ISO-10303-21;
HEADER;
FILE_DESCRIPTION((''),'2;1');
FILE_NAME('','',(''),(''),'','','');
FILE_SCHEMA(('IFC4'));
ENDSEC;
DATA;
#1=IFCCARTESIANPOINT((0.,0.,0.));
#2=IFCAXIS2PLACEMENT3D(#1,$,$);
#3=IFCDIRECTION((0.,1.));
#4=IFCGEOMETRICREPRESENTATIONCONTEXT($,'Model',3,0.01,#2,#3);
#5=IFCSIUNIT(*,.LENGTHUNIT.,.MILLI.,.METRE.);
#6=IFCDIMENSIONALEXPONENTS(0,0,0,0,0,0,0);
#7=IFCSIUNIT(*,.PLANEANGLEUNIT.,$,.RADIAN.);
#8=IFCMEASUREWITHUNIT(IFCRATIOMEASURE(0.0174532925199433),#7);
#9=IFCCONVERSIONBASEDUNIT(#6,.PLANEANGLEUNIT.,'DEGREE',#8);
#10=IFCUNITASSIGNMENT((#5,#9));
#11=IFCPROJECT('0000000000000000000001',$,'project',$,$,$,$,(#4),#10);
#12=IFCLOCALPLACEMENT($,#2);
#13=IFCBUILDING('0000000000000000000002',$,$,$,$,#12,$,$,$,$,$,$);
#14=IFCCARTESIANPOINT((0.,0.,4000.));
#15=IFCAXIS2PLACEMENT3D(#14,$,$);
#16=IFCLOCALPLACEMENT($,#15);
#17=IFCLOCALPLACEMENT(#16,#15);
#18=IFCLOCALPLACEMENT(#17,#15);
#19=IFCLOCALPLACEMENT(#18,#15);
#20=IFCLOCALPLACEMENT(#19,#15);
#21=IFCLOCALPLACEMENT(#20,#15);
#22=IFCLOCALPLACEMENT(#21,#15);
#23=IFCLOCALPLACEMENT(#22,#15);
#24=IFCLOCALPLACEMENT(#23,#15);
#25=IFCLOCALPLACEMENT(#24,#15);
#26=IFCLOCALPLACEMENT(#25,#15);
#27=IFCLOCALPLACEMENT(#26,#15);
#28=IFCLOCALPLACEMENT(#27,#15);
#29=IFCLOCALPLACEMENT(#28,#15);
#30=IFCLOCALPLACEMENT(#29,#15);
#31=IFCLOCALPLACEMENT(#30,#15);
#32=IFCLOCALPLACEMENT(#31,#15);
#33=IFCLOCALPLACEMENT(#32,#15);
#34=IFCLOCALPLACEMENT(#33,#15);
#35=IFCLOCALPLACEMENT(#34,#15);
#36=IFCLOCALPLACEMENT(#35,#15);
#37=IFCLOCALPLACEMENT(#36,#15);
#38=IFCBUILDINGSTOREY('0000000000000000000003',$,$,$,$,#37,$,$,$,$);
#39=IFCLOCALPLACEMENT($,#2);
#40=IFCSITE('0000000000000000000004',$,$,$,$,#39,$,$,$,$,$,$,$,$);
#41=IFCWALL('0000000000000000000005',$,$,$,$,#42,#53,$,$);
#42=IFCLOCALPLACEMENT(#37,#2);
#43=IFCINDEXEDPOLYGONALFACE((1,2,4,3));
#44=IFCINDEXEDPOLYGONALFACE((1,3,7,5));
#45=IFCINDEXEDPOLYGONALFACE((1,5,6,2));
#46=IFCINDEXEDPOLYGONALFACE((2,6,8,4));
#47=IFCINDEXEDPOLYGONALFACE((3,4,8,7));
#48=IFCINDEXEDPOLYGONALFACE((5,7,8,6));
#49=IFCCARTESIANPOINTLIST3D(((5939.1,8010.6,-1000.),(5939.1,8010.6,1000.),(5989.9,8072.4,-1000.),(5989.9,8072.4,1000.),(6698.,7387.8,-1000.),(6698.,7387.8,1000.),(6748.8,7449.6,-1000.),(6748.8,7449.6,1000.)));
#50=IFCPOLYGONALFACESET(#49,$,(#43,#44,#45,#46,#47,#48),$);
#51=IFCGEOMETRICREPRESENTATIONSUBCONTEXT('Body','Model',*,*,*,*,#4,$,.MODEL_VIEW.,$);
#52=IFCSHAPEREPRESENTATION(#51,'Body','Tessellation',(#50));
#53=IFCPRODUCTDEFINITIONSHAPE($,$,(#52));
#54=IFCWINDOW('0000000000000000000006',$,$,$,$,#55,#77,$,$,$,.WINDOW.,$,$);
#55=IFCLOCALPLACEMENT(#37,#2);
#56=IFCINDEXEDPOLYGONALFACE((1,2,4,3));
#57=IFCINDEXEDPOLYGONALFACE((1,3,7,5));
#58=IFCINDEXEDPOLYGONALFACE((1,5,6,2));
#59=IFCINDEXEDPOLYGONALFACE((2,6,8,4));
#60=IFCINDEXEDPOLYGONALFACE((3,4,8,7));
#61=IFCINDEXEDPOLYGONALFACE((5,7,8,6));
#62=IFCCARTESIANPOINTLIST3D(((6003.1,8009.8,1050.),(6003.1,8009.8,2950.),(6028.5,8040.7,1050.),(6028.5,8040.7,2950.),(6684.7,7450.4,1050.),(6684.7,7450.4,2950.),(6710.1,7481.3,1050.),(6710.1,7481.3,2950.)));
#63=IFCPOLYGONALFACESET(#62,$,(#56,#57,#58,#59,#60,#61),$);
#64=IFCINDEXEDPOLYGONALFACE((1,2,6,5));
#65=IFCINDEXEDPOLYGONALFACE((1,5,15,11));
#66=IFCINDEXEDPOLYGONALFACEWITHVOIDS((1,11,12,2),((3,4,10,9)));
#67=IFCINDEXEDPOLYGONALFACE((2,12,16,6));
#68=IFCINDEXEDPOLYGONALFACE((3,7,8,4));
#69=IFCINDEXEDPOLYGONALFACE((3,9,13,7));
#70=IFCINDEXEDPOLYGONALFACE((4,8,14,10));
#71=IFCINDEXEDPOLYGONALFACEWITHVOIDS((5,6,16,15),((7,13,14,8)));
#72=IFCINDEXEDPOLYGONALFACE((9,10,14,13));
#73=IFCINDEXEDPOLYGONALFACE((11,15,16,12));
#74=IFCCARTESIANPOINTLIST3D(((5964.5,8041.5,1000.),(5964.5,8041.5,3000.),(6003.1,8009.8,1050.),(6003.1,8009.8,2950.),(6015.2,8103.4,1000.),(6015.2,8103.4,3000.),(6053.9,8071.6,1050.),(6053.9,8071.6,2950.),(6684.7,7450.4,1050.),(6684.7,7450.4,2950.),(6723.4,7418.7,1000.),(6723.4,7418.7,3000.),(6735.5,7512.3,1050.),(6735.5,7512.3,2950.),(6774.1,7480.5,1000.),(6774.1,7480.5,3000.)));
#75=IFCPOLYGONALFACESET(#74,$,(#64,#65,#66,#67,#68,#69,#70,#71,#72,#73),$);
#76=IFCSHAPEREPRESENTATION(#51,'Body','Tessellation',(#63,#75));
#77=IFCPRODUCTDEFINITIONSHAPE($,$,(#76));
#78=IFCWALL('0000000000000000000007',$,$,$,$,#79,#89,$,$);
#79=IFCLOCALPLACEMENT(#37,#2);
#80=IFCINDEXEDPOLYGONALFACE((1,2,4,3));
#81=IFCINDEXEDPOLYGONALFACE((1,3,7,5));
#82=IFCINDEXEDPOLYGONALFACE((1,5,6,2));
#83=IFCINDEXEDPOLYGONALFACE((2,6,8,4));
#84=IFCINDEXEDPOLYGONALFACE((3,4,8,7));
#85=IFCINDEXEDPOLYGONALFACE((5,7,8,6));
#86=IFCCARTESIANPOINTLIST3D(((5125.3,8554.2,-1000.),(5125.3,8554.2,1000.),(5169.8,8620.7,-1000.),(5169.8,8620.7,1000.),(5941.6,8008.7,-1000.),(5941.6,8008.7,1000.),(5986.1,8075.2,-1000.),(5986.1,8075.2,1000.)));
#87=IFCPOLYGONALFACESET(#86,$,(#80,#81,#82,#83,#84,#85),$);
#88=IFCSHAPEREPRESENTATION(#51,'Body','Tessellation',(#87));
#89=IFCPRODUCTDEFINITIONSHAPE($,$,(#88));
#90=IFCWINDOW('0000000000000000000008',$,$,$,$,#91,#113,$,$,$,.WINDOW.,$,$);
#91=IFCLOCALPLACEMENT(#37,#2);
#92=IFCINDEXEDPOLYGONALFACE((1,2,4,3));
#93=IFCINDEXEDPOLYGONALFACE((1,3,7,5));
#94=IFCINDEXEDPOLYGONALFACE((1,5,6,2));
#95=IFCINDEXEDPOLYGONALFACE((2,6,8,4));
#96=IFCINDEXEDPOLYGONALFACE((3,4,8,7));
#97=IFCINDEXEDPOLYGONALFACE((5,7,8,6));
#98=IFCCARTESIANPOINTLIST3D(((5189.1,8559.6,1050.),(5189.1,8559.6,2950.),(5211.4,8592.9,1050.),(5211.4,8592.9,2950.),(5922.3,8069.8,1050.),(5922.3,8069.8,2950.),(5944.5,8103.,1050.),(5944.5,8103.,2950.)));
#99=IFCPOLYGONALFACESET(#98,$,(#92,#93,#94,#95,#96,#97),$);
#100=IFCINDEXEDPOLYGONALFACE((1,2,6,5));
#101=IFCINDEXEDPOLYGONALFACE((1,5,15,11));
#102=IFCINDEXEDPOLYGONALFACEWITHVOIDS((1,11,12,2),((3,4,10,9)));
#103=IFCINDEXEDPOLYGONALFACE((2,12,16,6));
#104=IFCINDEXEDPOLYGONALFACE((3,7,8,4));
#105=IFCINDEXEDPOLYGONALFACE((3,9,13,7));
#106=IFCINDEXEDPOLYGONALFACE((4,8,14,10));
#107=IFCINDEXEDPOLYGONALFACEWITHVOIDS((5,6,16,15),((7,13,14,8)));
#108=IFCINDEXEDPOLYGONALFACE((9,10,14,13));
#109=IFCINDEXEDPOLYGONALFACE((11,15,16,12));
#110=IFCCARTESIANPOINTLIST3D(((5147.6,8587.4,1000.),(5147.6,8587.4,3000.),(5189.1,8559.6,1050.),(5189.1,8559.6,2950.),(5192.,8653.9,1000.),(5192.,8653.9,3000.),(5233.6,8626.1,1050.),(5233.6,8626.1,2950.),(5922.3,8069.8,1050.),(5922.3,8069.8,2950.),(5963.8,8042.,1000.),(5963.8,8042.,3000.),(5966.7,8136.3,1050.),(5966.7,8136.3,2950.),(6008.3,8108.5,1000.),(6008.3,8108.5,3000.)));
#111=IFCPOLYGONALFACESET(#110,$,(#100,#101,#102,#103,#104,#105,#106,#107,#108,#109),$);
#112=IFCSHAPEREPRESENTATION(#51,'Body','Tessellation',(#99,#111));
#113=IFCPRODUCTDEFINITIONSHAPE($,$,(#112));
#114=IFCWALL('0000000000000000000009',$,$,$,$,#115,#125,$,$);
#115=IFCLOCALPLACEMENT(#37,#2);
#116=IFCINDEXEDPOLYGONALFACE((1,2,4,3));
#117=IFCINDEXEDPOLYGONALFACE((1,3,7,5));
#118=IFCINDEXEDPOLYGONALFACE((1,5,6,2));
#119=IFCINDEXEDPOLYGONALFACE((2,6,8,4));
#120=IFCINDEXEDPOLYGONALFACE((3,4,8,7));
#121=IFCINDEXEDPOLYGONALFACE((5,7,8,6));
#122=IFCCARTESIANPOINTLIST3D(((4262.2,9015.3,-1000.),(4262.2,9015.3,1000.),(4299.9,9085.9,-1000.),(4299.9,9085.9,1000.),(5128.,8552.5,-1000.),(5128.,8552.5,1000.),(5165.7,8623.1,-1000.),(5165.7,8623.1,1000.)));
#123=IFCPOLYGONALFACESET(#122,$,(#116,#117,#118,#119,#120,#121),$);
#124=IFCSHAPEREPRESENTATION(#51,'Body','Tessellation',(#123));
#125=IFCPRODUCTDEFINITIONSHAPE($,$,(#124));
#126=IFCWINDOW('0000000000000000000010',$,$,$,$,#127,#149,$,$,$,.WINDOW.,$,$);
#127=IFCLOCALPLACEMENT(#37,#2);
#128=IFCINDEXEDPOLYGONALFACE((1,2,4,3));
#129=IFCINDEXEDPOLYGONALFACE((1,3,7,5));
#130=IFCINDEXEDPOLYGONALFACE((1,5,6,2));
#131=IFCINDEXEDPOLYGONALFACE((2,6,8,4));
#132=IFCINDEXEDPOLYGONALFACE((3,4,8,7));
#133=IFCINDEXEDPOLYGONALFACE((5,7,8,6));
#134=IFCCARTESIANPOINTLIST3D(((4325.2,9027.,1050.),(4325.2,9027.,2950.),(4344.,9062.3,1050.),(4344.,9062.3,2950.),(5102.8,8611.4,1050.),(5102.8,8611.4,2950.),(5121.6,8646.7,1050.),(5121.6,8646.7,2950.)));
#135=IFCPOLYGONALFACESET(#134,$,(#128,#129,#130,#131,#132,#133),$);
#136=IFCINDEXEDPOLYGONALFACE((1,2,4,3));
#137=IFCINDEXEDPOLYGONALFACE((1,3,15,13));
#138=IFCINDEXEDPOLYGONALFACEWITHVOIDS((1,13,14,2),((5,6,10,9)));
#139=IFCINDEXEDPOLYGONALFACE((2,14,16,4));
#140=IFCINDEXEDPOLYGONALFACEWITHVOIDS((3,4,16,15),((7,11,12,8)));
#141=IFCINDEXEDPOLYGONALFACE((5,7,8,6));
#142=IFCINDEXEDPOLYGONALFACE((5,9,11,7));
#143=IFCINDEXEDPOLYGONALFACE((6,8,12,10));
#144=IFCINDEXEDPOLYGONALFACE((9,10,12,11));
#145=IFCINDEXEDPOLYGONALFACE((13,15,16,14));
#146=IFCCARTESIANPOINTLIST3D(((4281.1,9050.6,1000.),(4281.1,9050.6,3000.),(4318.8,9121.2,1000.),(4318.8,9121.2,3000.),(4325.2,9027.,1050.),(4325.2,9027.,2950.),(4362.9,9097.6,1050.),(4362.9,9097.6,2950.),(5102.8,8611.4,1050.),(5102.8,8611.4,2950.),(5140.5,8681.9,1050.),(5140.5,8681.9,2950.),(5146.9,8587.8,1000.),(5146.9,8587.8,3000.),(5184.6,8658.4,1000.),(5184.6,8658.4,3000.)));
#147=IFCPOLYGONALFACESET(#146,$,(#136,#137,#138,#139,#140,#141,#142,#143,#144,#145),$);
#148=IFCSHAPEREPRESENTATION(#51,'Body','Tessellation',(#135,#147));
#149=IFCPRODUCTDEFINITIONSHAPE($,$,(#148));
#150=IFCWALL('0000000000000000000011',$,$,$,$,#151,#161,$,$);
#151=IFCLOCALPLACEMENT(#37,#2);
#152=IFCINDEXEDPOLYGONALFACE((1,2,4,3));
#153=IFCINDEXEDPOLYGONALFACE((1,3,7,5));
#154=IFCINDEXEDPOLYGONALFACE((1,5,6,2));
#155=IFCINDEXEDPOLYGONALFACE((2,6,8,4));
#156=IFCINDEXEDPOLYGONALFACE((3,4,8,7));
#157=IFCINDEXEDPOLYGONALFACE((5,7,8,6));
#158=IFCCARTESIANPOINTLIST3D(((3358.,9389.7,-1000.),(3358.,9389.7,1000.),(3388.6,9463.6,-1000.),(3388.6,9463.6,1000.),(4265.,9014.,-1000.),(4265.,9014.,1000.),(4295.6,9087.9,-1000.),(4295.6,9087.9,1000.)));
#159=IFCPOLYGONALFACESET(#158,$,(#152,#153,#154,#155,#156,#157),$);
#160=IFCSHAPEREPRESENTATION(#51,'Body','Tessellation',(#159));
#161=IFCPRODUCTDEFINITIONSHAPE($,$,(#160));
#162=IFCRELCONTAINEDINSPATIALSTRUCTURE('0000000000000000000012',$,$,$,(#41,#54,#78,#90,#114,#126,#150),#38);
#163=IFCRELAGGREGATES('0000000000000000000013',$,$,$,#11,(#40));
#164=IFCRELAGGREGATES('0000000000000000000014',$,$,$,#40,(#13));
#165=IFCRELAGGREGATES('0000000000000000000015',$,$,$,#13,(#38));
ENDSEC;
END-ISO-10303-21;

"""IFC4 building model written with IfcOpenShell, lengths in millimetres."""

from ifc_helpers import new_model, entity, si_unit, converted_unit, direction, frame, origin, origin_2d, place, context, subcontext, project, spatial, rectangle, extrude, element, save


model = new_model("IFC4")

# Units and contexts
model_context = context("Model", 3, precision=0.01, world=origin(), true_north=direction((0.0, 1.0)))
body_context = subcontext(model_context, "Body", "Model", "MODEL_VIEW")
ifc_project = project(units=[si_unit("LENGTHUNIT", "METRE", prefix="MILLI"), converted_unit("PLANEANGLEUNIT", "DEGREE", entity("IfcRatioMeasure", 0.0174532925199433), si_unit("PLANEANGLEUNIT", "RADIAN"), dimensions=[0, 0, 0, 0, 0, 0, 0])], contexts=[model_context])

# Site, building, storey
site_placement = place(None, origin())
site = spatial("IfcSite", under=ifc_project, at=site_placement)
building_placement = place(None, origin())
building = spatial("IfcBuilding", under=site, at=building_placement)
placement_1 = place(None, frame((0.0, 0.0, 4000.0)))
placement_2 = place(placement_1, frame((0.0, 0.0, 4000.0)))
placement_3 = place(placement_2, frame((0.0, 0.0, 4000.0)))
placement_4 = place(placement_3, frame((0.0, 0.0, 4000.0)))
placement_5 = place(placement_4, frame((0.0, 0.0, 4000.0)))
placement_6 = place(placement_5, frame((0.0, 0.0, 4000.0)))
placement_7 = place(placement_6, frame((0.0, 0.0, 4000.0)))
placement_8 = place(placement_7, frame((0.0, 0.0, 4000.0)))
placement_9 = place(placement_8, frame((0.0, 0.0, 4000.0)))
placement_10 = place(placement_9, frame((0.0, 0.0, 4000.0)))
placement_11 = place(placement_10, frame((0.0, 0.0, 4000.0)))
placement_12 = place(placement_11, frame((0.0, 0.0, 4000.0)))
placement_13 = place(placement_12, frame((0.0, 0.0, 4000.0)))
placement_14 = place(placement_13, frame((0.0, 0.0, 4000.0)))
placement_15 = place(placement_14, frame((0.0, 0.0, 4000.0)))
placement_16 = place(placement_15, frame((0.0, 0.0, 4000.0)))
placement_17 = place(placement_16, frame((0.0, 0.0, 4000.0)))
placement_18 = place(placement_17, frame((0.0, 0.0, 4000.0)))
placement_19 = place(placement_18, frame((0.0, 0.0, 4000.0)))
placement_20 = place(placement_19, frame((0.0, 0.0, 4000.0)))
placement_21 = place(placement_20, frame((0.0, 0.0, 4000.0)))
storey_placement = place(placement_21, frame((0.0, 0.0, 4000.0)))
storey = spatial("IfcBuildingStorey", under=building, at=storey_placement)

# Wall
wall_1_placement = place(storey_placement, frame((6343.9, 7730.1, -1000.0), z_axis=(0.0, 0.0, 1.0), x_axis=(-7730.104548, 6343.932824, 0.0)))
element("IfcWall", 1, at=wall_1_placement, inside=storey, context=body_context, shape_type="SweptSolid", body=[
    extrude(rectangle(XDim=981.7, YDim=80.0, at=origin_2d()), origin(), (0.0, 0.0, 1.0), 2000.0),
])

# Window
cartesian_point_1 = entity("IfcCartesianPoint", [-440.9, -950.0])
shared_polyline = entity("IfcPolyline", [cartesian_point_1, entity("IfcCartesianPoint", [-440.9, 950.0]), entity("IfcCartesianPoint", [-440.9, 950.0]), entity("IfcCartesianPoint", [440.9, 950.0]), entity("IfcCartesianPoint", [440.9, 950.0]), entity("IfcCartesianPoint", [440.9, -950.0]), entity("IfcCartesianPoint", [440.9, -950.0]), entity("IfcCartesianPoint", [-440.9, -950.0]), cartesian_point_1])
window_1_placement = place(storey_placement, frame((6343.9, 7730.1, 2000.0), z_axis=(0.0, 0.0, 1.0), x_axis=(-7730.104548, 6343.932824, 0.0)))
cartesian_point_2 = entity("IfcCartesianPoint", [-490.9, -1000.0])
element("IfcWindow", 2, at=window_1_placement, inside=storey, PredefinedType="WINDOW", context=body_context, shape_type="SweptSolid", body=[
    entity("IfcExtrudedAreaSolid", entity("IfcArbitraryClosedProfileDef", "AREA", None, shared_polyline), entity("IfcAxis2Placement3D", entity("IfcCartesianPoint", [0.0, 0.0, 0.0]), entity("IfcDirection", [0.0, -1.0, 0.0]), entity("IfcDirection", [1.0, 0.0, 0.0])), entity("IfcDirection", [0.0, 0.0, 1.0]), 40.0),
    entity("IfcExtrudedAreaSolid", entity("IfcArbitraryProfileDefWithVoids", "AREA", None, entity("IfcPolyline", [cartesian_point_2, entity("IfcCartesianPoint", [-490.9, 1000.0]), entity("IfcCartesianPoint", [-490.9, 1000.0]), entity("IfcCartesianPoint", [490.9, 1000.0]), entity("IfcCartesianPoint", [490.9, 1000.0]), entity("IfcCartesianPoint", [490.9, -1000.0]), entity("IfcCartesianPoint", [490.9, -1000.0]), entity("IfcCartesianPoint", [-490.9, -1000.0]), cartesian_point_2]), [shared_polyline]), entity("IfcAxis2Placement3D", entity("IfcCartesianPoint", [0.0, 0.0, 0.0]), entity("IfcDirection", [0.0, -1.0, 0.0]), entity("IfcDirection", [1.0, 0.0, 0.0])), entity("IfcDirection", [0.0, 0.0, 1.0]), 80.0),
])

# Wall
wall_2_placement = place(storey_placement, frame((5555.7, 8314.7, -1000.0), z_axis=(0.0, 0.0, 1.0), x_axis=(-8314.696026, 5555.702475, 0.0)))
element("IfcWall", 3, at=wall_2_placement, inside=storey, context=body_context, shape_type="SweptSolid", body=[
    extrude(rectangle(XDim=981.7, YDim=80.0, at=origin_2d()), origin(), (0.0, 0.0, 1.0), 2000.0),
])

# Window
window_2_placement = place(storey_placement, frame((5555.7, 8314.7, 2000.0), z_axis=(0.0, 0.0, 1.0), x_axis=(-8314.696026, 5555.702475, 0.0)))
cartesian_point_3 = entity("IfcCartesianPoint", [-490.9, -1000.0])
element("IfcWindow", 4, at=window_2_placement, inside=storey, PredefinedType="WINDOW", context=body_context, shape_type="SweptSolid", body=[
    entity("IfcExtrudedAreaSolid", entity("IfcArbitraryClosedProfileDef", "AREA", None, shared_polyline), entity("IfcAxis2Placement3D", entity("IfcCartesianPoint", [0.0, 0.0, 0.0]), entity("IfcDirection", [0.0, -1.0, 0.0]), entity("IfcDirection", [1.0, 0.0, 0.0])), entity("IfcDirection", [0.0, 0.0, 1.0]), 40.0),
    entity("IfcExtrudedAreaSolid", entity("IfcArbitraryProfileDefWithVoids", "AREA", None, entity("IfcPolyline", [cartesian_point_3, entity("IfcCartesianPoint", [-490.9, 1000.0]), entity("IfcCartesianPoint", [-490.9, 1000.0]), entity("IfcCartesianPoint", [490.9, 1000.0]), entity("IfcCartesianPoint", [490.9, 1000.0]), entity("IfcCartesianPoint", [490.9, -1000.0]), entity("IfcCartesianPoint", [490.9, -1000.0]), entity("IfcCartesianPoint", [-490.9, -1000.0]), cartesian_point_3]), [shared_polyline]), entity("IfcAxis2Placement3D", entity("IfcCartesianPoint", [0.0, 0.0, 0.0]), entity("IfcDirection", [0.0, -1.0, 0.0]), entity("IfcDirection", [1.0, 0.0, 0.0])), entity("IfcDirection", [0.0, 0.0, 1.0]), 80.0),
])

# Wall
wall_3_placement = place(storey_placement, frame((4714.0, 8819.2, -1000.0), z_axis=(0.0, 0.0, 1.0), x_axis=(-8819.212469, 4713.967695, 0.0)))
element("IfcWall", 5, at=wall_3_placement, inside=storey, context=body_context, shape_type="SweptSolid", body=[
    extrude(rectangle(XDim=981.7, YDim=80.0, at=origin_2d()), origin(), (0.0, 0.0, 1.0), 2000.0),
])

# Window
window_3_placement = place(storey_placement, frame((4714.0, 8819.2, 2000.0), z_axis=(0.0, 0.0, 1.0), x_axis=(-8819.212469, 4713.967695, 0.0)))
cartesian_point_4 = entity("IfcCartesianPoint", [-490.9, -1000.0])
element("IfcWindow", 6, at=window_3_placement, inside=storey, PredefinedType="WINDOW", context=body_context, shape_type="SweptSolid", body=[
    entity("IfcExtrudedAreaSolid", entity("IfcArbitraryClosedProfileDef", "AREA", None, shared_polyline), entity("IfcAxis2Placement3D", entity("IfcCartesianPoint", [0.0, 0.0, 0.0]), entity("IfcDirection", [0.0, -1.0, 0.0]), entity("IfcDirection", [1.0, 0.0, 0.0])), entity("IfcDirection", [0.0, 0.0, 1.0]), 40.0),
    entity("IfcExtrudedAreaSolid", entity("IfcArbitraryProfileDefWithVoids", "AREA", None, entity("IfcPolyline", [cartesian_point_4, entity("IfcCartesianPoint", [-490.9, 1000.0]), entity("IfcCartesianPoint", [-490.9, 1000.0]), entity("IfcCartesianPoint", [490.9, 1000.0]), entity("IfcCartesianPoint", [490.9, 1000.0]), entity("IfcCartesianPoint", [490.9, -1000.0]), entity("IfcCartesianPoint", [490.9, -1000.0]), entity("IfcCartesianPoint", [-490.9, -1000.0]), cartesian_point_4]), [shared_polyline]), entity("IfcAxis2Placement3D", entity("IfcCartesianPoint", [0.0, 0.0, 0.0]), entity("IfcDirection", [0.0, -1.0, 0.0]), entity("IfcDirection", [1.0, 0.0, 0.0])), entity("IfcDirection", [0.0, 0.0, 1.0]), 80.0),
])

# Wall
wall_4_placement = place(storey_placement, frame((3826.8, 9238.8, -1000.0), z_axis=(0.0, 0.0, 1.0), x_axis=(-9238.795337, 3826.834296, 0.0)))
element("IfcWall", 7, at=wall_4_placement, inside=storey, context=body_context, shape_type="SweptSolid", body=[
    extrude(rectangle(XDim=981.7, YDim=80.0, at=origin_2d()), origin(), (0.0, 0.0, 1.0), 2000.0),
])

save(model, "model.ifc")
